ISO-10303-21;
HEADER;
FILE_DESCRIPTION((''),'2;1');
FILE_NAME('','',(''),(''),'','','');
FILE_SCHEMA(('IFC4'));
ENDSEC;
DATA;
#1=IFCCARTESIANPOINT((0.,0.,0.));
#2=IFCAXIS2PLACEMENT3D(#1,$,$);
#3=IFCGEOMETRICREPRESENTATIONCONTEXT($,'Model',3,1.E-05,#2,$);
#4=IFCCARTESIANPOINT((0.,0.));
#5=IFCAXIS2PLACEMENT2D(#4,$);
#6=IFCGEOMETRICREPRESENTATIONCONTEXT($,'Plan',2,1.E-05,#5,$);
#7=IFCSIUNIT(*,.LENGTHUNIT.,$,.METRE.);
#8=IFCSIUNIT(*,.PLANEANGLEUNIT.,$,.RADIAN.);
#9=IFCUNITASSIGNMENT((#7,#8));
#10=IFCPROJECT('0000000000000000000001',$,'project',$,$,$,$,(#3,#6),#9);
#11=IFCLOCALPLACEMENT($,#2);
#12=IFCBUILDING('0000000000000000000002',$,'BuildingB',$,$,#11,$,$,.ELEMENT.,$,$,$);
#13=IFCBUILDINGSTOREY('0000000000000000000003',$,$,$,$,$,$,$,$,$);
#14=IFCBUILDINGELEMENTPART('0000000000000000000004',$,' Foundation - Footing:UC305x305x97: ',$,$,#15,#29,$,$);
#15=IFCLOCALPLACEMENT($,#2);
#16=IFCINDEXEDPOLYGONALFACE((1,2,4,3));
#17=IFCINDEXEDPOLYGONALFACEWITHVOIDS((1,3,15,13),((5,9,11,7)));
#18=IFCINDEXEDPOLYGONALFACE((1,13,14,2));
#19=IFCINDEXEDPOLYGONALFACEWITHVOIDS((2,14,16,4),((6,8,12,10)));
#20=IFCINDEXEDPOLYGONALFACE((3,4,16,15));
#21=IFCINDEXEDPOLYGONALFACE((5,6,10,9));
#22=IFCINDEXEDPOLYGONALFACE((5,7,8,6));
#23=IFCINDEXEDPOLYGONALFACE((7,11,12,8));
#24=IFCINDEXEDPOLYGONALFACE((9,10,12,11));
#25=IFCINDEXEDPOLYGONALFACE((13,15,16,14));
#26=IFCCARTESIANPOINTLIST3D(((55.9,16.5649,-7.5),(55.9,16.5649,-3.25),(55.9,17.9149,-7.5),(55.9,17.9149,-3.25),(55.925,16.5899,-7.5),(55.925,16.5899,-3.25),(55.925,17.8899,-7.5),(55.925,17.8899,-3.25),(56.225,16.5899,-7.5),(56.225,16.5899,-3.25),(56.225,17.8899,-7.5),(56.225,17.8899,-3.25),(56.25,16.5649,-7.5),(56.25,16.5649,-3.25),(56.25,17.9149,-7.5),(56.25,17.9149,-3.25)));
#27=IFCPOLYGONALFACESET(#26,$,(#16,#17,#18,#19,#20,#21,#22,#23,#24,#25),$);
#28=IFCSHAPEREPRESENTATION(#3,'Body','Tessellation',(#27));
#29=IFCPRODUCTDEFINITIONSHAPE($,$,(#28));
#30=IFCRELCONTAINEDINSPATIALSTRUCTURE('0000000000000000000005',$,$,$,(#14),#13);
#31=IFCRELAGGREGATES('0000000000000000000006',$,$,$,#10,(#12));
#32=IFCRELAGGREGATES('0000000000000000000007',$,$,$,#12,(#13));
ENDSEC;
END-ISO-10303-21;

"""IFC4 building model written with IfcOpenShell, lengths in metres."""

from ifc_helpers import new_model, si_unit, origin, origin_2d, place, context, project, spatial, polyline, outline, extrude, element, save


model = new_model("IFC4")

# Units and contexts
model_context = context("Model", 3, precision=1e-05, world=origin())
plan_context = context("Plan", 2, precision=1e-05, world=origin_2d())
ifc_project = project(units=[si_unit("LENGTHUNIT", "METRE"), si_unit("PLANEANGLEUNIT", "RADIAN")], contexts=[model_context, plan_context])

# Building, storey
building_placement = place(None, origin())
building = spatial("IfcBuilding", under=ifc_project, at=building_placement, Name="BuildingB", CompositionType="ELEMENT")
storey = spatial("IfcBuildingStorey", under=building)

# Building element part, opening
building_element_part_1 = element("IfcBuildingElementPart", 1, inside=storey, Name=" Foundation - Footing:UC305x305x97: ", context=model_context, shape_type="SweptSolid", body=[
    extrude(outline(polyline([(55.9, 17.9149, -7.5), (55.9, 16.5649, -7.5), (56.25, 16.5649, -7.5), (56.25, 17.9149, -7.5), (55.9, 17.9149, -7.5)])), None, (0.0, 0.0, 1.0), 4.25),
])
element("IfcOpeningElement", 2, inside=storey, cuts=building_element_part_1, context=model_context, shape_type="SweptSolid", body=[
    extrude(outline(polyline([(55.925, 17.8899, -7.5), (55.925, 16.5899, -7.5), (56.225, 16.5899, -7.5), (56.225, 17.8899, -7.5), (55.925, 17.8899, -7.5)])), None, (0.0, 0.0, 1.0), 4.25),
])

save(model, "model.ifc")
